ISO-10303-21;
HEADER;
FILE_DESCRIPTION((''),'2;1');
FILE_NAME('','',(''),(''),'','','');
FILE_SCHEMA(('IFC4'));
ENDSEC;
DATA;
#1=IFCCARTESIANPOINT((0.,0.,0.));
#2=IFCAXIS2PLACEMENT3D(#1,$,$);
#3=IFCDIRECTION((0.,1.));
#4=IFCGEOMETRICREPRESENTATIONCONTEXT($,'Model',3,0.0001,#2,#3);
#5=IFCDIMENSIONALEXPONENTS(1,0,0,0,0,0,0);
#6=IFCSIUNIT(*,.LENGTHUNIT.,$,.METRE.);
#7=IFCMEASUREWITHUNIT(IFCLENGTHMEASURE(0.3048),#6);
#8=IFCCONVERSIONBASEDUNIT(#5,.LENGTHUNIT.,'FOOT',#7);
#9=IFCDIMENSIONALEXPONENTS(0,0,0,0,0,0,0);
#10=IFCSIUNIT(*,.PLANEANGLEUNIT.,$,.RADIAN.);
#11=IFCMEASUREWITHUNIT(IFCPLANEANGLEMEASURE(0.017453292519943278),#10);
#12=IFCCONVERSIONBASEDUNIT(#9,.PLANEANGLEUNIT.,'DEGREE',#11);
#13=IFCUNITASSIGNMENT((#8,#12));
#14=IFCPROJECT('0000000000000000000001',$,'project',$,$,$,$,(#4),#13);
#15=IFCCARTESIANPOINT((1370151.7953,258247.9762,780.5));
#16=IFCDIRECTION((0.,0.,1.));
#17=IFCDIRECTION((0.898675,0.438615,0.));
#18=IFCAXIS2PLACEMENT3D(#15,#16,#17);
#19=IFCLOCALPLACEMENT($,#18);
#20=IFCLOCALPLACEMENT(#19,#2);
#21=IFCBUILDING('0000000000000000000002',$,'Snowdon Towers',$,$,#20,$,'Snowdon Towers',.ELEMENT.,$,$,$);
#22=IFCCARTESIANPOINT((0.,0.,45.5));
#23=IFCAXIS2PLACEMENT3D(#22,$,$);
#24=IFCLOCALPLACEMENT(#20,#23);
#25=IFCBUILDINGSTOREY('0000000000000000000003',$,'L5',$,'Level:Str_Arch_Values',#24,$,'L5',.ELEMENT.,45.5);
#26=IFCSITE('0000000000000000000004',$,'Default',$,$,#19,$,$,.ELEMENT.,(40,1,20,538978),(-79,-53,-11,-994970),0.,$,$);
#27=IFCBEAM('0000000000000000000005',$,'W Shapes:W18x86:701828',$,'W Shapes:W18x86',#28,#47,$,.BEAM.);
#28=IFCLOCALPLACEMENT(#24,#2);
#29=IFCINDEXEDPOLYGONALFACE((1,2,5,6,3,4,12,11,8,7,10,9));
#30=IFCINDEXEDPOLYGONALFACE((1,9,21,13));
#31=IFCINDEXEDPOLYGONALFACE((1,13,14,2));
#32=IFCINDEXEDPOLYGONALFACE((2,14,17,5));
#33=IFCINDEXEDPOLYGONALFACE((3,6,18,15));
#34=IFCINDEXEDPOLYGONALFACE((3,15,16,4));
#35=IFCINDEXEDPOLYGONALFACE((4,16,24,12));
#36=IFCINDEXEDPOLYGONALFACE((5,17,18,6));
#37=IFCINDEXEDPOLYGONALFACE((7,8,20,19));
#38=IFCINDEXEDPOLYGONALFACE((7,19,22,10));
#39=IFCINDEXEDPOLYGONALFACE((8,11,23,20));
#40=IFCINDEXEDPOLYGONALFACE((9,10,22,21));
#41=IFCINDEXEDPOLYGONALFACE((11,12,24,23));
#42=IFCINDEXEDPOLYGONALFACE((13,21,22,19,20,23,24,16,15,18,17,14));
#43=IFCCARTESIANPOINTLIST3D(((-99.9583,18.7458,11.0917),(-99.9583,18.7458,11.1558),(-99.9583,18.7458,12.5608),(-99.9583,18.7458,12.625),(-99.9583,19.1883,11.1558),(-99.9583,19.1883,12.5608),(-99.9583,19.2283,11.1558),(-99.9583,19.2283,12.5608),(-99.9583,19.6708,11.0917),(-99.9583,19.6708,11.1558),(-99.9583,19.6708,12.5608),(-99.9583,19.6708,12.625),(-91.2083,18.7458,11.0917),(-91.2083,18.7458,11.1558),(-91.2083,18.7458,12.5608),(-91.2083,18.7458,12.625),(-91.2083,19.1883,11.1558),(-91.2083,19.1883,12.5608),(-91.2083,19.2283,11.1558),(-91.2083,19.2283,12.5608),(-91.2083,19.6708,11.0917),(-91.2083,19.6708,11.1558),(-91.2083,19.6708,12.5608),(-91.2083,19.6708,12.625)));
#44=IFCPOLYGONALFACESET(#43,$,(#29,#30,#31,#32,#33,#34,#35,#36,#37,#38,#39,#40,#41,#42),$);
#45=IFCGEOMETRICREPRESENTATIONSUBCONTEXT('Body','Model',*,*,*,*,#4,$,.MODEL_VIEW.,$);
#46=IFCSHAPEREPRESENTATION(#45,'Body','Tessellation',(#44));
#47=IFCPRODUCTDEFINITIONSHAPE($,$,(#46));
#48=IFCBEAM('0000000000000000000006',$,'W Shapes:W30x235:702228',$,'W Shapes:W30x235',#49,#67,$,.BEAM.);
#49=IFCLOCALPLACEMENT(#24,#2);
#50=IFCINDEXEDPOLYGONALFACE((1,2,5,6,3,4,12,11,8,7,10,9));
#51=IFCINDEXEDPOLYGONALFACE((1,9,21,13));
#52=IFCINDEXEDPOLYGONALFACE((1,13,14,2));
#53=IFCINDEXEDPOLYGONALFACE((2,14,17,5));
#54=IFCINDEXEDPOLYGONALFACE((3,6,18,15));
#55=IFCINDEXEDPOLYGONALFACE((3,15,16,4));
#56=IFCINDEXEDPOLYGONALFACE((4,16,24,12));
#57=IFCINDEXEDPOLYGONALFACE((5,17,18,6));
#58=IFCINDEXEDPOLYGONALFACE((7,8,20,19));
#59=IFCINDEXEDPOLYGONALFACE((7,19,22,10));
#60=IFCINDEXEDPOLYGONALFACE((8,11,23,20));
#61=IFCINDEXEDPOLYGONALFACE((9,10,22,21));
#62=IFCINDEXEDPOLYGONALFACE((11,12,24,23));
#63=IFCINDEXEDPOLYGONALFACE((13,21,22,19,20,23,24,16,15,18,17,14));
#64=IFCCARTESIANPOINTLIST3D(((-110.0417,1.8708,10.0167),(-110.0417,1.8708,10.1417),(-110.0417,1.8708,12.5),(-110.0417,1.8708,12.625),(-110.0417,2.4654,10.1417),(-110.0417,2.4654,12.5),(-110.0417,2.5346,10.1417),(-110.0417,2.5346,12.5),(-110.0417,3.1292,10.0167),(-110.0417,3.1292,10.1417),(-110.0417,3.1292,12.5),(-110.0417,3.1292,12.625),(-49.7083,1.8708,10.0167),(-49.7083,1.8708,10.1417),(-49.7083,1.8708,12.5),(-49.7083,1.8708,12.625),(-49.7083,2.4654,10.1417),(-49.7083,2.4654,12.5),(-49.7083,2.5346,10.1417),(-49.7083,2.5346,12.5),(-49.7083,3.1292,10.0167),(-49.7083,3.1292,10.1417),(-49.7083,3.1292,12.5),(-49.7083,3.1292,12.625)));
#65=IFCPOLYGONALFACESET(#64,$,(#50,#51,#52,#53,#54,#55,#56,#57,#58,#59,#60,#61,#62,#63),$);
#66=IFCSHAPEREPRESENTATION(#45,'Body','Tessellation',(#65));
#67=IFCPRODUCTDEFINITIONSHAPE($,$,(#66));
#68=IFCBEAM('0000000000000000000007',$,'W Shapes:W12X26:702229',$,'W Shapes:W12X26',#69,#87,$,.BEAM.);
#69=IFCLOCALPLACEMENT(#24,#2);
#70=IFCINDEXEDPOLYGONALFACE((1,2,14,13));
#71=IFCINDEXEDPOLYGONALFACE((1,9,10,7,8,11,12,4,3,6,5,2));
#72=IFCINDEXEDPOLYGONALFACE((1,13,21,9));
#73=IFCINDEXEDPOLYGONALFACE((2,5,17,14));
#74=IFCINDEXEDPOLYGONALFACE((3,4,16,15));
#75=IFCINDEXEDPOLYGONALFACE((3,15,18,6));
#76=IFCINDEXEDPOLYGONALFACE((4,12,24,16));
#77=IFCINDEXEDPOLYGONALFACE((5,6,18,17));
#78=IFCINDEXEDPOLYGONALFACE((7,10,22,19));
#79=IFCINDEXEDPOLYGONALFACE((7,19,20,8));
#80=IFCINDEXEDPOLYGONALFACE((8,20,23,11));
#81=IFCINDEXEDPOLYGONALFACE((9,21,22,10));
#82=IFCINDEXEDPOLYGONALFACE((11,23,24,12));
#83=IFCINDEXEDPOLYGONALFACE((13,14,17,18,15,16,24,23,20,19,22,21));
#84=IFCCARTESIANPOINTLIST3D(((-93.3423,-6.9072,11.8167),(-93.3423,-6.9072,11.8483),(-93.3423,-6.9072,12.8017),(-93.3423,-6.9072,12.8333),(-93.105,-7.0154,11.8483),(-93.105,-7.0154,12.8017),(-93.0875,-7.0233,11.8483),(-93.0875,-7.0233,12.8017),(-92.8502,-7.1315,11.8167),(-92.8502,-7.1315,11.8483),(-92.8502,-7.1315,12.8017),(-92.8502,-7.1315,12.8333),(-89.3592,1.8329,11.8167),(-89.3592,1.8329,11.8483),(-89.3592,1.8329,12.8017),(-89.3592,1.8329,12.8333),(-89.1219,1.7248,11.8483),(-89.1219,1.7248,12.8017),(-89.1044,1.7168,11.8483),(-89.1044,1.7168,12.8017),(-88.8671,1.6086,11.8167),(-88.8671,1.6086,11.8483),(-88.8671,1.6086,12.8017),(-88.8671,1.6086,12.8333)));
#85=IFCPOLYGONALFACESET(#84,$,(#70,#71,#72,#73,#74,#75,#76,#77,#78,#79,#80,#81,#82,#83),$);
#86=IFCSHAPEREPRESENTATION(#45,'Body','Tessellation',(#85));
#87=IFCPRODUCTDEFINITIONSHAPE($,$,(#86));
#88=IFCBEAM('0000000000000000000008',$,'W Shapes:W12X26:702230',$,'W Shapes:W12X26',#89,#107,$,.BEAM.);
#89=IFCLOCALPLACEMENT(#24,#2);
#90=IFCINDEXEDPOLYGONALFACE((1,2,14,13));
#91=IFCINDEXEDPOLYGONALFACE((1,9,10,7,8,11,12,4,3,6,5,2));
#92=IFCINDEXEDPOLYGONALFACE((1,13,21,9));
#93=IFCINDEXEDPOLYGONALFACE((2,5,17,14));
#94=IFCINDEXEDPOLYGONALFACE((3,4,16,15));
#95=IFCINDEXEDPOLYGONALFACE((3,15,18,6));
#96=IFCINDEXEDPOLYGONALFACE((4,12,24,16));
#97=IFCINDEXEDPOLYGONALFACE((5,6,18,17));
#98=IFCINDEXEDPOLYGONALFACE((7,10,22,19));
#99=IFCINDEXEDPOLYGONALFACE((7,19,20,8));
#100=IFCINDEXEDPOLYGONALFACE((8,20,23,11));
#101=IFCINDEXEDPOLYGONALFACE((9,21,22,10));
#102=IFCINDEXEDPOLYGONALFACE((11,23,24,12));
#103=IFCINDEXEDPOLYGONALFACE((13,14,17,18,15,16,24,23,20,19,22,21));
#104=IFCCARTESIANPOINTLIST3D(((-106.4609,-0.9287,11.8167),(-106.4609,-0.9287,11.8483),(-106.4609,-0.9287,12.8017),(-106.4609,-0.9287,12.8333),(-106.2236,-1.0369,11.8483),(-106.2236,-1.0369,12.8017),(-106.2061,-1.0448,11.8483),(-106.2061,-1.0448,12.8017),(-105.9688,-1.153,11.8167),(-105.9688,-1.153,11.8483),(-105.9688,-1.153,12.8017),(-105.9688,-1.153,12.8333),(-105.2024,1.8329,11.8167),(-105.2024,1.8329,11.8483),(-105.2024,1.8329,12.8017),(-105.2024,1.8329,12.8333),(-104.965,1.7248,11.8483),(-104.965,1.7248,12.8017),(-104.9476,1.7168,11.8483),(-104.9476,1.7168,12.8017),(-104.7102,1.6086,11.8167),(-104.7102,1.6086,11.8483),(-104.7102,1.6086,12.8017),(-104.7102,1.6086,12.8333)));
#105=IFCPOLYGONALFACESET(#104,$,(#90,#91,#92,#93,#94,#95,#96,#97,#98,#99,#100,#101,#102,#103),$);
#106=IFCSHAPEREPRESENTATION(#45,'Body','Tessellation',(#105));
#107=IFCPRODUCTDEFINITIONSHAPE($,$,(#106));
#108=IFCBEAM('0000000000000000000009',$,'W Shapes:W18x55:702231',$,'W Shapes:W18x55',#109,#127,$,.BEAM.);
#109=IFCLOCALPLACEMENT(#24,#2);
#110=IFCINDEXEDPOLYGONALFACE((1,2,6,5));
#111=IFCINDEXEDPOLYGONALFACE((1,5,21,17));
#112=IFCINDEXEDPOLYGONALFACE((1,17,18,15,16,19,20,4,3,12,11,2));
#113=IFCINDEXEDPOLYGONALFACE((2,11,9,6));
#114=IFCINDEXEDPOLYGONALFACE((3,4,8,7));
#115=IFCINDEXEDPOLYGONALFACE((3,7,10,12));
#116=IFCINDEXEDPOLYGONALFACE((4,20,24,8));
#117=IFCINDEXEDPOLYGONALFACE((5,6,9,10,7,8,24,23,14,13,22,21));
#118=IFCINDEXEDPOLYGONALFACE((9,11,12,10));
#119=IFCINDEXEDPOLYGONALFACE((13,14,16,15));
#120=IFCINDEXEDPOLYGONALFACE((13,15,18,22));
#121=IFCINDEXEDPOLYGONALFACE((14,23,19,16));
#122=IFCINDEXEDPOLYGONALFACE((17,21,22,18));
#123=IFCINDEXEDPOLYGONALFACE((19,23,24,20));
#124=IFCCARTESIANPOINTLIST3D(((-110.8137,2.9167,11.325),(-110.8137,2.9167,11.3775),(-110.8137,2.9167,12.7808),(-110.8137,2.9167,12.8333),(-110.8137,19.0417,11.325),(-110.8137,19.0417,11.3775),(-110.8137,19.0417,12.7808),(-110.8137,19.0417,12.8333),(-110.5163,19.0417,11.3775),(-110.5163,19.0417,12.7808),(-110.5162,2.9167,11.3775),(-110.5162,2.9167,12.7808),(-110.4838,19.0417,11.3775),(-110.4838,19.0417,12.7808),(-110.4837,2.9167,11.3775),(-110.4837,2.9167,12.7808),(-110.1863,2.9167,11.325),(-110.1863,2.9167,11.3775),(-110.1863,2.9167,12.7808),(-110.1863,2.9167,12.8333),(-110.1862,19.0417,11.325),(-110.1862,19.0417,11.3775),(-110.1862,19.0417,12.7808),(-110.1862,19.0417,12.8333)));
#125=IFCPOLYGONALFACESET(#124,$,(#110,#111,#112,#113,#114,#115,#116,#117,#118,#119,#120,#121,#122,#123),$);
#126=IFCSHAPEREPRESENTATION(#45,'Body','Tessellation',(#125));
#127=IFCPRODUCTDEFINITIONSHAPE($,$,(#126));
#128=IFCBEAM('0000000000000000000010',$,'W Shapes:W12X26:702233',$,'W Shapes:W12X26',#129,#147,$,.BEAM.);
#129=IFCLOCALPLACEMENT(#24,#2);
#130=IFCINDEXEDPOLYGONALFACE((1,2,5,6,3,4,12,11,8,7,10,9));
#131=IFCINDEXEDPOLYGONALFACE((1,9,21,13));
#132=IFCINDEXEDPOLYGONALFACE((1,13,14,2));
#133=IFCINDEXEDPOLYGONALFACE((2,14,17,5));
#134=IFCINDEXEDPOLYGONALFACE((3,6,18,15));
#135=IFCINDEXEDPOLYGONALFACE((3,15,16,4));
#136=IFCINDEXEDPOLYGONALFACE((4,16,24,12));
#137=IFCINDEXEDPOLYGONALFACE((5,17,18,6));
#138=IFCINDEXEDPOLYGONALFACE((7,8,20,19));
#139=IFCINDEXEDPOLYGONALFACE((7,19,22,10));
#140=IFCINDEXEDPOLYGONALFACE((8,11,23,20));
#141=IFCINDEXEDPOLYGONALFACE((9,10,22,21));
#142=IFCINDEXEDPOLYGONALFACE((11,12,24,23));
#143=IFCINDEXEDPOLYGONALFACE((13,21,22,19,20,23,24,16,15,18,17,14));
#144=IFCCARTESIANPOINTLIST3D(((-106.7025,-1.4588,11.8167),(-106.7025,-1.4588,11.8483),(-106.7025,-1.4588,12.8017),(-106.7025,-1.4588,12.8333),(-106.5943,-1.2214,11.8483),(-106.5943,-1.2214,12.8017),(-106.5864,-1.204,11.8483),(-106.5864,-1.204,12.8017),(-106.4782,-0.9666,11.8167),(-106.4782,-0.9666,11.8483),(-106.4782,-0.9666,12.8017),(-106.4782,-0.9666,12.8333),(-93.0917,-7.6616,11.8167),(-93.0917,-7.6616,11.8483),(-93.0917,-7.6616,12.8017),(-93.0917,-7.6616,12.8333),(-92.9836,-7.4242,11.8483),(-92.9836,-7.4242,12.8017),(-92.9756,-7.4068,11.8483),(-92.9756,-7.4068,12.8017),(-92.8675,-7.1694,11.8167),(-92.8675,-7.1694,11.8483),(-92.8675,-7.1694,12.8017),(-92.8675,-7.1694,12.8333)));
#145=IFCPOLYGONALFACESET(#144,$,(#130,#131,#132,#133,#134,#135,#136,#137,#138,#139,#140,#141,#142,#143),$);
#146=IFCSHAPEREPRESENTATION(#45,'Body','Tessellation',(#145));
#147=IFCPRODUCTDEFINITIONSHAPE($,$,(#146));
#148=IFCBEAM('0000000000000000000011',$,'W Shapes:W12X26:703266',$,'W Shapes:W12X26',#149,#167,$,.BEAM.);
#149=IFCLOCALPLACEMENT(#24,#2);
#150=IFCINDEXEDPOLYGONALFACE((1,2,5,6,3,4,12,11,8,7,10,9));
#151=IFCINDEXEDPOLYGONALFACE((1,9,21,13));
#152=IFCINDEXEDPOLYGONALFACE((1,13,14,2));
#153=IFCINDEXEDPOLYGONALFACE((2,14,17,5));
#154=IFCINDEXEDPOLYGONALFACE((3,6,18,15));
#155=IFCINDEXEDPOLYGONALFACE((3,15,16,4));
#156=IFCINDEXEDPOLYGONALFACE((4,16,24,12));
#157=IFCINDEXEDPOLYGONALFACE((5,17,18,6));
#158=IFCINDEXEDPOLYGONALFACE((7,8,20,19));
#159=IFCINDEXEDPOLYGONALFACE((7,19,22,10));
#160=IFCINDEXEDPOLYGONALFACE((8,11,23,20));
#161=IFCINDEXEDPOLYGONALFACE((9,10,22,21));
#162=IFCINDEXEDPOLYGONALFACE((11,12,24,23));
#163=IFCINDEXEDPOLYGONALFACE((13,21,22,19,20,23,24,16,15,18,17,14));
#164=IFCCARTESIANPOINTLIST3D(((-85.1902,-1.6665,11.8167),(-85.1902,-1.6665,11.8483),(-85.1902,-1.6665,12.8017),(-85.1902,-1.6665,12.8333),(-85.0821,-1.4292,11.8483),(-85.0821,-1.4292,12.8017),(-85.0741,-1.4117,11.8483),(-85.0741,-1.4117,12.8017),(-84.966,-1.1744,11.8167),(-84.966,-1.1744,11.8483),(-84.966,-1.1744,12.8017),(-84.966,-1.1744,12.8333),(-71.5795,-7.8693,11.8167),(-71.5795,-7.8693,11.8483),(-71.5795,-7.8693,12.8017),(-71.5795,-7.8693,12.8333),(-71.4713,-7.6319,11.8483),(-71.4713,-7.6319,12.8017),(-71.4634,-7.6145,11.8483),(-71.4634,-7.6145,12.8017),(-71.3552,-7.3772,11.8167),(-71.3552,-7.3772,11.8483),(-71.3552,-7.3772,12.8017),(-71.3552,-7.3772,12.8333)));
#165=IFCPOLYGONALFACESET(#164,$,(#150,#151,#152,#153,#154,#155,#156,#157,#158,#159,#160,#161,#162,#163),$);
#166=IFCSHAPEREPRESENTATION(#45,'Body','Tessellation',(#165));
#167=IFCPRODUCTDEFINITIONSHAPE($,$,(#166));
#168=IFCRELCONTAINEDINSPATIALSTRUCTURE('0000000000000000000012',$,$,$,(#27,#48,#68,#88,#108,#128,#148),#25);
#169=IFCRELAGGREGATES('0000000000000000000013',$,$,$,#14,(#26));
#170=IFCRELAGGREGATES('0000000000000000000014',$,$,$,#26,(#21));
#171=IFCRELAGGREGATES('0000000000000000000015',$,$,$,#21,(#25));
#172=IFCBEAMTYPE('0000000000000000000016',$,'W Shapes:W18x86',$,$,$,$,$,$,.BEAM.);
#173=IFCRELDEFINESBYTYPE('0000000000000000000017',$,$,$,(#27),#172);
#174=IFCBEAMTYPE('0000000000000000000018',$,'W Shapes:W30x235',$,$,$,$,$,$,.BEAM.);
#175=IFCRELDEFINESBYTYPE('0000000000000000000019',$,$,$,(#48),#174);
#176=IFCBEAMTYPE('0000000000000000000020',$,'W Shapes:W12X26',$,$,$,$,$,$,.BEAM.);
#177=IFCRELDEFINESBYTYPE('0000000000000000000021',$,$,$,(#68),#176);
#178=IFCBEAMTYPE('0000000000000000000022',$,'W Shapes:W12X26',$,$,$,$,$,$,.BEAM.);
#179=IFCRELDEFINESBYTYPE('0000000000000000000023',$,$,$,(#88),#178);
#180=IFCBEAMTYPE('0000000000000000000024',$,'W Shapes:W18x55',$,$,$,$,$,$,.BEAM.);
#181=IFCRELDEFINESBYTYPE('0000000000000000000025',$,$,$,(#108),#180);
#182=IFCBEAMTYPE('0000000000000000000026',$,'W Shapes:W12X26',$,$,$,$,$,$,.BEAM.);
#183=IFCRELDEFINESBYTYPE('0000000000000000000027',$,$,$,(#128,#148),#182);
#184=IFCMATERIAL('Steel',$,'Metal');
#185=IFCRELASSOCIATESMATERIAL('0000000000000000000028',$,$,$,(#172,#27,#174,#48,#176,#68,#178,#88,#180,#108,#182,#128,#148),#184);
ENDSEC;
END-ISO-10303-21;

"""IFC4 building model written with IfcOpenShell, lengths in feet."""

from ifc_helpers import new_model, entity, si_unit, converted_unit, direction, frame, origin, place, context, subcontext, project, spatial, indexed_curve, outline, extrude, source, transform, mapped, material, type_object, type_shapes, element, save


model = new_model("IFC4")

# Units and contexts
model_context = context("Model", 3, precision=0.0001, world=origin(), true_north=direction((0.0, 1.0)))
body_context = subcontext(model_context, "Body", "Model", "MODEL_VIEW")
ifc_project = project(units=[converted_unit("LENGTHUNIT", "FOOT", entity("IfcLengthMeasure", 0.3048), si_unit("LENGTHUNIT", "METRE"), dimensions=[1, 0, 0, 0, 0, 0, 0]), converted_unit("PLANEANGLEUNIT", "DEGREE", entity("IfcPlaneAngleMeasure", 0.017453292519943278), si_unit("PLANEANGLEUNIT", "RADIAN"), dimensions=[0, 0, 0, 0, 0, 0, 0])], contexts=[model_context])

# Site, building, storey
site_placement = place(None, frame((1370151.7953, 258247.9762, 780.5), z_axis=(0.0, 0.0, 1.0), x_axis=(0.898675, 0.438615, 0.0)))
site = spatial("IfcSite", under=ifc_project, at=site_placement, Name="Default", CompositionType="ELEMENT", RefLatitude=(40, 1, 20, 538978), RefLongitude=(-79, -53, -11, -994970), RefElevation=0.0)
building_placement = place(site_placement, origin())
building = spatial("IfcBuilding", under=site, at=building_placement, Name="Snowdon Towers", LongName="Snowdon Towers", CompositionType="ELEMENT")
storey_placement = place(building_placement, frame((0.0, 0.0, 45.5)))
storey = spatial("IfcBuildingStorey", under=building, at=storey_placement, Name="L5", ObjectType="Level:Str_Arch_Values", LongName="L5", CompositionType="ELEMENT", Elevation=45.5)

# Beams
ifc_material = material(Name="Steel", Category="Metal")
beam_type_1 = type_object("IfcBeamType", Name="W Shapes:W18x86", PredefinedType="BEAM", material=ifc_material)
shared_shape_1 = source(origin(), body_context, "Body", "SweptSolid", [
    extrude(outline(indexed_curve([(-0.4625, -0.7025), (-0.4625, -0.7667), (0.4625, -0.7667), (0.4625, -0.7025), (0.02, -0.7025), (0.02, 0.7025), (0.4625, 0.7025), (0.4625, 0.7667), (-0.4625, 0.7667), (-0.4625, 0.7025), (-0.02, 0.7025), (-0.02, -0.7025), (-0.4625, -0.7025)], self_intersect=False)), frame((-4.6042, 0.0, 0.0), z_axis=(-1.0, 0.0, 0.0), x_axis=(0.0, -1.0, 0.0)), (0.0, 0.0, -1.0), 8.75),
])
type_shapes(beam_type_1, [shared_shape_1])
beam_1_placement = place(storey_placement, frame((-95.3542, 19.2083, 11.8583)))
element("IfcBeam", 1, at=beam_1_placement, inside=storey, type_object=beam_type_1, material=ifc_material, Name="W Shapes:W18x86:701828", ObjectType="W Shapes:W18x86", PredefinedType="BEAM", context=body_context, shape_type="MappedRepresentation", body=[
    mapped(shared_shape_1, transform((0.0, 0.0, 0.0), scale=1.0)),
])
beam_type_2 = type_object("IfcBeamType", Name="W Shapes:W30x235", PredefinedType="BEAM", material=ifc_material)
shared_shape_2 = source(origin(), body_context, "Body", "SweptSolid", [
    extrude(outline(indexed_curve([(-0.6292, -1.1792), (-0.6292, -1.3042), (0.6292, -1.3042), (0.6292, -1.1792), (0.0346, -1.1792), (0.0346, 1.1792), (0.6292, 1.1792), (0.6292, 1.3042), (-0.6292, 1.3042), (-0.6292, 1.1792), (-0.0346, 1.1792), (-0.0346, -1.1792), (-0.6292, -1.1792)], self_intersect=False)), frame((-29.9167, 0.0, 0.0), z_axis=(-1.0, 0.0, 0.0), x_axis=(0.0, -1.0, 0.0)), (0.0, 0.0, -1.0), 60.3333),
])
type_shapes(beam_type_2, [shared_shape_2])
beam_2_placement = place(storey_placement, frame((-80.125, 2.5, 11.3208)))
element("IfcBeam", 2, at=beam_2_placement, inside=storey, type_object=beam_type_2, material=ifc_material, Name="W Shapes:W30x235:702228", ObjectType="W Shapes:W30x235", PredefinedType="BEAM", context=body_context, shape_type="MappedRepresentation", body=[
    mapped(shared_shape_2, transform((0.0, 0.0, 0.0), scale=1.0)),
])
beam_type_3 = type_object("IfcBeamType", Name="W Shapes:W12X26", PredefinedType="BEAM", material=ifc_material)
shared_shape_3 = source(origin(), body_context, "Body", "SweptSolid", [
    extrude(outline(indexed_curve([(-0.2704, -0.4767), (-0.2704, -0.5083), (0.2704, -0.5083), (0.2704, -0.4767), (0.0096, -0.4767), (0.0096, 0.4767), (0.2704, 0.4767), (0.2704, 0.5083), (-0.2704, 0.5083), (-0.2704, 0.4767), (-0.0096, 0.4767), (-0.0096, -0.4767), (-0.2704, -0.4767)], self_intersect=False)), frame((-5.0746, 0.0, 0.0), z_axis=(-1.0, 0.0, 0.0), x_axis=(0.0, -1.0, 0.0)), (0.0, 0.0, -1.0), 9.605),
])
type_shapes(beam_type_3, [shared_shape_3])
beam_3_placement = place(storey_placement, frame((-90.9918, -2.4017, 12.325), z_axis=(0.0, 0.0, 1.0), x_axis=(0.414693, 0.909961, 0.0)))
element("IfcBeam", 3, at=beam_3_placement, inside=storey, type_object=beam_type_3, material=ifc_material, Name="W Shapes:W12X26:702229", ObjectType="W Shapes:W12X26", PredefinedType="BEAM", context=body_context, shape_type="MappedRepresentation", body=[
    mapped(shared_shape_3, transform((0.0, 0.0, 0.0), scale=1.0)),
])
beam_type_4 = type_object("IfcBeamType", Name="W Shapes:W12X26", PredefinedType="BEAM", material=ifc_material)
shared_shape_4 = source(origin(), body_context, "Body", "SweptSolid", [
    extrude(outline(indexed_curve([(-0.2704, -0.4767), (-0.2704, -0.5083), (0.2704, -0.5083), (0.2704, -0.4767), (0.0096, -0.4767), (0.0096, 0.4767), (0.2704, 0.4767), (0.2704, 0.5083), (-0.2704, 0.5083), (-0.2704, 0.4767), (-0.0096, 0.4767), (-0.0096, -0.4767), (-0.2704, -0.4767)], self_intersect=False)), frame((-1.7896, 0.0, 0.0), z_axis=(-1.0, 0.0, 0.0), x_axis=(0.0, -1.0, 0.0)), (0.0, 0.0, -1.0), 3.0349),
])
type_shapes(beam_type_4, [shared_shape_4])
beam_4_placement = place(storey_placement, frame((-105.4727, 0.5876, 12.325), z_axis=(0.0, 0.0, 1.0), x_axis=(0.414693, 0.909961, 0.0)))
element("IfcBeam", 4, at=beam_4_placement, inside=storey, type_object=beam_type_4, material=ifc_material, Name="W Shapes:W12X26:702230", ObjectType="W Shapes:W12X26", PredefinedType="BEAM", context=body_context, shape_type="MappedRepresentation", body=[
    mapped(shared_shape_4, transform((0.0, 0.0, 0.0), scale=1.0)),
])
beam_type_5 = type_object("IfcBeamType", Name="W Shapes:W18x55", PredefinedType="BEAM", material=ifc_material)
shared_shape_5 = source(origin(), body_context, "Body", "SweptSolid", [
    extrude(outline(indexed_curve([(-0.3138, -0.7017), (-0.3138, -0.7542), (0.3138, -0.7542), (0.3138, -0.7017), (0.0162, -0.7017), (0.0162, 0.7017), (0.3138, 0.7017), (0.3138, 0.7542), (-0.3137, 0.7542), (-0.3137, 0.7017), (-0.0163, 0.7017), (-0.0163, -0.7017), (-0.3138, -0.7017)], self_intersect=False)), frame((-7.8542, 0.0, 0.0), z_axis=(-1.0, 0.0, 0.0), x_axis=(0.0, -1.0, 0.0)), (0.0, 0.0, -1.0), 16.125),
])
type_shapes(beam_type_5, [shared_shape_5])
beam_5_placement = place(storey_placement, frame((-110.5, 10.7708, 12.0792), z_axis=(0.0, 0.0, 1.0), x_axis=(0.0, 1.0, 0.0)))
element("IfcBeam", 5, at=beam_5_placement, inside=storey, type_object=beam_type_5, material=ifc_material, Name="W Shapes:W18x55:702231", ObjectType="W Shapes:W18x55", PredefinedType="BEAM", context=body_context, shape_type="MappedRepresentation", body=[
    mapped(shared_shape_5, transform((0.0, 0.0, 0.0), scale=1.0)),
])
beam_type_6 = type_object("IfcBeamType", Name="W Shapes:W12X26", PredefinedType="BEAM", material=ifc_material)
shared_shape_6 = source(origin(), body_context, "Body", "SweptSolid", [
    extrude(outline(indexed_curve([(-0.2704, -0.4767), (-0.2704, -0.5083), (0.2704, -0.5083), (0.2704, -0.4767), (0.0096, -0.4767), (0.0096, 0.4767), (0.2704, 0.4767), (0.2704, 0.5083), (-0.2704, 0.5083), (-0.2704, 0.4767), (-0.0096, 0.4767), (-0.0096, -0.4767), (-0.2704, -0.4767)], self_intersect=False)), frame((-7.4787, 0.0, 0.0), z_axis=(-1.0, 0.0, 0.0), x_axis=(0.0, -1.0, 0.0)), (0.0, 0.0, -1.0), 14.9575),
])
type_shapes(beam_type_6, [shared_shape_6])
for number, where, z_axis, x_axis, name in (
    (6, (-99.785, -4.3141, 12.325), (0.0, 0.0, 1.0), (0.909961, -0.414693, 0.0), "W Shapes:W12X26:702233"),
    (7, (-78.2727, -4.5218, 12.325), (0.0, 0.0, 1.0), (0.909961, -0.414693, 0.0), "W Shapes:W12X26:703266"),
):
    element("IfcBeam", number, at=place(storey_placement, frame(where, z_axis=z_axis, x_axis=x_axis)), inside=storey, type_object=beam_type_6, material=ifc_material, Name=name, ObjectType="W Shapes:W12X26", PredefinedType="BEAM", context=body_context, shape_type="MappedRepresentation", body=[
        mapped(shared_shape_6, transform((0.0, 0.0, 0.0), scale=1.0)),
    ])

save(model, "model.ifc")
